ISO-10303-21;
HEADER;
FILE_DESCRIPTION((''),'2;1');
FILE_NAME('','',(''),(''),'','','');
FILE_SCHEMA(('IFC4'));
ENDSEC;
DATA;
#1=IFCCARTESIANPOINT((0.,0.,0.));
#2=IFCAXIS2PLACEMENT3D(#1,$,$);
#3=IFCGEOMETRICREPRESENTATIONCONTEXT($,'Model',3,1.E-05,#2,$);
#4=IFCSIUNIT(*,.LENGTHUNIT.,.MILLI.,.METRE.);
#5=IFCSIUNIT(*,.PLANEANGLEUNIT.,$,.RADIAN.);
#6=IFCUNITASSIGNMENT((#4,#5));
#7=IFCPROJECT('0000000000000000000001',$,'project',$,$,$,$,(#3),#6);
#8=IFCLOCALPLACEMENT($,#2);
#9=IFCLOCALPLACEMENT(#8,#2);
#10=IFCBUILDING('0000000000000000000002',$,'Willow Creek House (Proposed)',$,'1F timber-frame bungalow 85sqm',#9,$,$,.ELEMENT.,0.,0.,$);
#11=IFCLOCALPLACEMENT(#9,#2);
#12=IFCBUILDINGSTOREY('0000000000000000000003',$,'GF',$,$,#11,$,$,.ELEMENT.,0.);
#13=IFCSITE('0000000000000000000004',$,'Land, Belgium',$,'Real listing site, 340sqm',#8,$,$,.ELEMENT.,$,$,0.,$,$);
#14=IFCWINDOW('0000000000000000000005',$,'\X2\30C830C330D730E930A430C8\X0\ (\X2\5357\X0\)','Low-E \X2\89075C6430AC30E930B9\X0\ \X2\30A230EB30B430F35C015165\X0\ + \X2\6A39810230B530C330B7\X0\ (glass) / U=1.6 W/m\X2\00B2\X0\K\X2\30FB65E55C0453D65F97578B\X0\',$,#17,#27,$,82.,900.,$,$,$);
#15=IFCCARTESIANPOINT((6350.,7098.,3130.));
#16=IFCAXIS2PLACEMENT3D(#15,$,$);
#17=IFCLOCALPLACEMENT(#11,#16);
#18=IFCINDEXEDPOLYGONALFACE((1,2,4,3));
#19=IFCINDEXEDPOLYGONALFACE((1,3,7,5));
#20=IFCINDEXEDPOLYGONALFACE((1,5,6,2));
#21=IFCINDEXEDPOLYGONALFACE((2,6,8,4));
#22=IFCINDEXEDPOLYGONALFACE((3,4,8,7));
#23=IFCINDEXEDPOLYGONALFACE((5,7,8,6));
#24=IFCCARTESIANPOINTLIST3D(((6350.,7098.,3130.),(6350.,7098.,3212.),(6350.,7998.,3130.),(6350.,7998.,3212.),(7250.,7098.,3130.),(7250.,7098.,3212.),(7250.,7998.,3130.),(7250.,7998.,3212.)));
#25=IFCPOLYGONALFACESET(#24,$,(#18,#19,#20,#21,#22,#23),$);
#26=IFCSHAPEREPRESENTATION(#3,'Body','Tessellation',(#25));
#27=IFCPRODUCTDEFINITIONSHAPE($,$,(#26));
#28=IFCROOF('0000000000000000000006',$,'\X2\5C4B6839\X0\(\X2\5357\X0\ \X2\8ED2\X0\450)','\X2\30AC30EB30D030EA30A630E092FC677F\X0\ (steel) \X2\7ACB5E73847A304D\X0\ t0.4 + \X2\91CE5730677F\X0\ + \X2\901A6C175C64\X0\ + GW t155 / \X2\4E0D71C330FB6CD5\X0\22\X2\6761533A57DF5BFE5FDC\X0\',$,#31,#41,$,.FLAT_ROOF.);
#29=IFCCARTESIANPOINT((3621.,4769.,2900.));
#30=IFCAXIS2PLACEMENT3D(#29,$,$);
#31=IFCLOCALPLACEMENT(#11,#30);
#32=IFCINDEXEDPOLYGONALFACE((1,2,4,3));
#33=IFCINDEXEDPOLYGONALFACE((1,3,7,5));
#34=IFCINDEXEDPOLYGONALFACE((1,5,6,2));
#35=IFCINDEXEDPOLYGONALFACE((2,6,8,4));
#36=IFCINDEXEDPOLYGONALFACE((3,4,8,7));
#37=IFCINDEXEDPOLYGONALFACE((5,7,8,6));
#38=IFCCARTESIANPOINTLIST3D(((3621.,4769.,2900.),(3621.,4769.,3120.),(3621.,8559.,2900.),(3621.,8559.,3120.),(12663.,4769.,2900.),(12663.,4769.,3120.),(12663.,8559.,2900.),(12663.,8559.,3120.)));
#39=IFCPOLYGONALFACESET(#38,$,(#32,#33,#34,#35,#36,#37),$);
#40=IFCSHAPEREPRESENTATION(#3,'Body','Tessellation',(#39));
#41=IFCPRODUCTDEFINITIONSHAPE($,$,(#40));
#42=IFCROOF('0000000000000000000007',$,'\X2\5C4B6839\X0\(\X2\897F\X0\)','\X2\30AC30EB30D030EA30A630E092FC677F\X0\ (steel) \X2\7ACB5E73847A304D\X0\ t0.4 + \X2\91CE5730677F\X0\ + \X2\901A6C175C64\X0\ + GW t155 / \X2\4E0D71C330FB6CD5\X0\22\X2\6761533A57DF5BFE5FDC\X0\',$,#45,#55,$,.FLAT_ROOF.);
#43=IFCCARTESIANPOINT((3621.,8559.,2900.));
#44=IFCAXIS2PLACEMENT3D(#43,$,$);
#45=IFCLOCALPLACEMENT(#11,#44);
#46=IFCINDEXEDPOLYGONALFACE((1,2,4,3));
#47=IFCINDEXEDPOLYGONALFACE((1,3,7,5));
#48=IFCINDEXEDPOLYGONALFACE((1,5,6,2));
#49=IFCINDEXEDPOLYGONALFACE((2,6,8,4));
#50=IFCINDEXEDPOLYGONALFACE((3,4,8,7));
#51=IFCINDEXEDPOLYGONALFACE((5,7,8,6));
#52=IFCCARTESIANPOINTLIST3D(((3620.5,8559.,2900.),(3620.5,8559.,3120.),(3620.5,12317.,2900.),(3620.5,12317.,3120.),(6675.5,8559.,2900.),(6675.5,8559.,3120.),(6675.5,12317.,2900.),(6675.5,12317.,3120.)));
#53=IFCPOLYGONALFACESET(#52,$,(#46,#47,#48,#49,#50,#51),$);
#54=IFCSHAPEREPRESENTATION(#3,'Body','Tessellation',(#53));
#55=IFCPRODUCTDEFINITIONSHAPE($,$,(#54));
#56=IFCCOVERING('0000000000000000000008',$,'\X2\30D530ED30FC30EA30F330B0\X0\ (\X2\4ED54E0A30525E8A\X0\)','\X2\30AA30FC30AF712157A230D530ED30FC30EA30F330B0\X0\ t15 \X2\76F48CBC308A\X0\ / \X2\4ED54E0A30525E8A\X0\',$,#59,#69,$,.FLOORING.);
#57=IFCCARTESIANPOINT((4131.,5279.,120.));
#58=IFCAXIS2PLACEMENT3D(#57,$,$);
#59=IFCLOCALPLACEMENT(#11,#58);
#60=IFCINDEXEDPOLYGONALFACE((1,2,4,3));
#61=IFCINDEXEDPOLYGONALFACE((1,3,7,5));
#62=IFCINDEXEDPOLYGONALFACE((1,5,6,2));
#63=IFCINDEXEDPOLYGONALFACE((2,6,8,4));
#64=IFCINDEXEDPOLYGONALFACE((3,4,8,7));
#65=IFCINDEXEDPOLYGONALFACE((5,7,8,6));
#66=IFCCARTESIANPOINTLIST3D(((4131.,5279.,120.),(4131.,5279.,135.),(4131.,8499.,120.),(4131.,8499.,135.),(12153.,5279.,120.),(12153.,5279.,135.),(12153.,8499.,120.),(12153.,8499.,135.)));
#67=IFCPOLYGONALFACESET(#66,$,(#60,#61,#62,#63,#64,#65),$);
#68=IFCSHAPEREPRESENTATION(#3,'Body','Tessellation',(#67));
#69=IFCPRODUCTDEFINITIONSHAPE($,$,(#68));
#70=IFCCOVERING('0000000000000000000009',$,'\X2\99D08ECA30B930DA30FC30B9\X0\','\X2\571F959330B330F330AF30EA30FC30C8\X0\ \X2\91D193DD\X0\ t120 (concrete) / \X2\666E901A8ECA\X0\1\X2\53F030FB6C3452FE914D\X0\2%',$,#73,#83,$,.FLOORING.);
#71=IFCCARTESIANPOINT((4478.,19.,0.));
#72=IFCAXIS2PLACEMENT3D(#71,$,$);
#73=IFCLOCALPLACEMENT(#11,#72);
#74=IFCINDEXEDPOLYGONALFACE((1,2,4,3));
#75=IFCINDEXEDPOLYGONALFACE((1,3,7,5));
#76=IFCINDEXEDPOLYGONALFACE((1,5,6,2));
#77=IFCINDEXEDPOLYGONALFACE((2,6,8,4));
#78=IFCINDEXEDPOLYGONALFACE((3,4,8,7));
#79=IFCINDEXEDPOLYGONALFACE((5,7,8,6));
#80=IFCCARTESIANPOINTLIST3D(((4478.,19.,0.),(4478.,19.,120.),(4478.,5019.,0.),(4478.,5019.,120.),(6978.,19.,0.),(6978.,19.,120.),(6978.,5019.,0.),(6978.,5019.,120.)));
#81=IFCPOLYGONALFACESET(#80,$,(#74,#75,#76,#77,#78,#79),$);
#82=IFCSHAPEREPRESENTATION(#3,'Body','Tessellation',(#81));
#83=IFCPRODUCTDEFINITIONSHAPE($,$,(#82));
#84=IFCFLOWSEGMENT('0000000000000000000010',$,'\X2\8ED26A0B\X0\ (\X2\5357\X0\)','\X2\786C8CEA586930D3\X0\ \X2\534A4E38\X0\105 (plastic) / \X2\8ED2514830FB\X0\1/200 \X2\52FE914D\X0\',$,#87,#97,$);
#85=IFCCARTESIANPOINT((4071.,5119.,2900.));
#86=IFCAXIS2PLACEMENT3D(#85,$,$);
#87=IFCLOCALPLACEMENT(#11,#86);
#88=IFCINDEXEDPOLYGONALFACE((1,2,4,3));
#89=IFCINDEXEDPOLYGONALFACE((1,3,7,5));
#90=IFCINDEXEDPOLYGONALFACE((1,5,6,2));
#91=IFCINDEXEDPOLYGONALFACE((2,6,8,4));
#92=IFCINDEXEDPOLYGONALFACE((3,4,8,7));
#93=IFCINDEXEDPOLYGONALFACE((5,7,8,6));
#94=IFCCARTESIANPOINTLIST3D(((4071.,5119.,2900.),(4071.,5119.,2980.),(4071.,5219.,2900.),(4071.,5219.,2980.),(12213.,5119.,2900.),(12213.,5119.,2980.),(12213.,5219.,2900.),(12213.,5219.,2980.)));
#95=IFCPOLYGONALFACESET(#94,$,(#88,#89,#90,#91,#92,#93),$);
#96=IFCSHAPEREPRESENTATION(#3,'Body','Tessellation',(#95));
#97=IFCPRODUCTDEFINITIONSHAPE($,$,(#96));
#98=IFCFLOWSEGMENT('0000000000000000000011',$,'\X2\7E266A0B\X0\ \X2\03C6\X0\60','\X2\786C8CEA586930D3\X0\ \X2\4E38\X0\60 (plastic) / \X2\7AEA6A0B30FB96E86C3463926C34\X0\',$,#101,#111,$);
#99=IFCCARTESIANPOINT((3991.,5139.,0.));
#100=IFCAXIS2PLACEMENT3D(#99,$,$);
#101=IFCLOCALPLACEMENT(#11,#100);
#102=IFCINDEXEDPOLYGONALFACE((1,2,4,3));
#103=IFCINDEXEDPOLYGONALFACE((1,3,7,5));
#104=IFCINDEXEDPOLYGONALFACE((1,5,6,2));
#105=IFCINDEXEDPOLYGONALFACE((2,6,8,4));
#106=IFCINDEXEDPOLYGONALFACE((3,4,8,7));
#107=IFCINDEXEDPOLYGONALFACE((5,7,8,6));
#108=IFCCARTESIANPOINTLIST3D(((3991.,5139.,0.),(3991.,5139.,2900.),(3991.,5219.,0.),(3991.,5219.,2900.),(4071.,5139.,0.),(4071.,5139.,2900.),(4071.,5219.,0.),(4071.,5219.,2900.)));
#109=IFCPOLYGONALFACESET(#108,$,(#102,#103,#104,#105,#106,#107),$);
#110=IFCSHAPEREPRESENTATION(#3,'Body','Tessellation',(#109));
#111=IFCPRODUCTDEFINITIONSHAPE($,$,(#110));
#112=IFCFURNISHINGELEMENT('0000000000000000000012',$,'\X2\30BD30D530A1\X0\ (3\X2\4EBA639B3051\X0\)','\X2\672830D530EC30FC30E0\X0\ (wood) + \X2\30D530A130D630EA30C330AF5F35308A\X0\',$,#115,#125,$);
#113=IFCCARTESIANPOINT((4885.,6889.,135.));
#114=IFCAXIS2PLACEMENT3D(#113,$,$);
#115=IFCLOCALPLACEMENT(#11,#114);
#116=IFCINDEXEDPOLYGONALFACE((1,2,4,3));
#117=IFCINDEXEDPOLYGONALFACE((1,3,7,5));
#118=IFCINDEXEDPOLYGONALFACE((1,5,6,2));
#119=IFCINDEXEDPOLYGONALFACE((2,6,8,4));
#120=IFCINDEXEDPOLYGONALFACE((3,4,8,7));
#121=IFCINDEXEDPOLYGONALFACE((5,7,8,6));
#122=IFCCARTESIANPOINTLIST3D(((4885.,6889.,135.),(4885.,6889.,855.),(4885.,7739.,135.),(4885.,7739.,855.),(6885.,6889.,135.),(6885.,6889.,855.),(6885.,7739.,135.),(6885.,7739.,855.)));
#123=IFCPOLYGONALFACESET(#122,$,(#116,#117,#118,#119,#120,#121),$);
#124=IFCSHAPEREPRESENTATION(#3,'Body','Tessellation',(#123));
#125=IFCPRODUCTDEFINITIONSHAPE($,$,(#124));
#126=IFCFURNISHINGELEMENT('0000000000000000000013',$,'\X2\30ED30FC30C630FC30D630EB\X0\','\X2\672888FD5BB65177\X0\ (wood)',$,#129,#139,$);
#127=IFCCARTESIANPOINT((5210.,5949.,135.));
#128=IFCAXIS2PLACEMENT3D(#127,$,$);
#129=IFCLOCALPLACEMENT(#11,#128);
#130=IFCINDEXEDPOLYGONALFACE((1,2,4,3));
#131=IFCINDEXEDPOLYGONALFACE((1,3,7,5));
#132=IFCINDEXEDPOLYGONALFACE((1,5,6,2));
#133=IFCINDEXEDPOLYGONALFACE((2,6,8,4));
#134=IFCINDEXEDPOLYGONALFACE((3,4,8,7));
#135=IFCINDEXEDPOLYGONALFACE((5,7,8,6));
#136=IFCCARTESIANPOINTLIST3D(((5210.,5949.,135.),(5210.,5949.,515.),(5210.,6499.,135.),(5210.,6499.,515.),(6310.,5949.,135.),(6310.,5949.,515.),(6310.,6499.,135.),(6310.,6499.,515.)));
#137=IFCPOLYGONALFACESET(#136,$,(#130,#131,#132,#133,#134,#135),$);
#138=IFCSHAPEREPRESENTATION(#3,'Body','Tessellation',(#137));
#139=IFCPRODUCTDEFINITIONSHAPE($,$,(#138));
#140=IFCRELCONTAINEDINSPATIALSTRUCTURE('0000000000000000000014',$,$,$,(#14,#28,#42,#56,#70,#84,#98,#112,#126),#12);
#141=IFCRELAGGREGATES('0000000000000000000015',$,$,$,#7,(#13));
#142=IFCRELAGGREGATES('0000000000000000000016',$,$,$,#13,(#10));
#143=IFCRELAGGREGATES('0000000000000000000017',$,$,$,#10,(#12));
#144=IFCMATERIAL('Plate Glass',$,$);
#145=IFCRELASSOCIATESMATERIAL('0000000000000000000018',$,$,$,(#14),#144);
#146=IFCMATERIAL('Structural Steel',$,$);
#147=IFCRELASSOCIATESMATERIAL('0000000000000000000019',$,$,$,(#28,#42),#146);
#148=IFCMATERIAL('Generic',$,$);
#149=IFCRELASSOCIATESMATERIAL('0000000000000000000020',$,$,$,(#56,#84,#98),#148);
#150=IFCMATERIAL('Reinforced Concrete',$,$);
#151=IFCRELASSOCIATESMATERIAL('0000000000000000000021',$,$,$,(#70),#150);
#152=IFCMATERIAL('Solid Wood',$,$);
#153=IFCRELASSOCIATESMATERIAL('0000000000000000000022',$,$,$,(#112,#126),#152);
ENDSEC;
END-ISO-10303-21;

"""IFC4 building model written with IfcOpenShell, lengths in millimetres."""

from ifc_helpers import new_model, si_unit, frame, frame_2d, origin, place, context, project, spatial, rectangle, extrude, material, element, save


model = new_model("IFC4")

# Units and contexts
model_context = context("Model", 3, precision=1e-05, world=origin())
ifc_project = project(units=[si_unit("LENGTHUNIT", "METRE", prefix="MILLI"), si_unit("PLANEANGLEUNIT", "RADIAN")], contexts=[model_context])

# Site, building, storey
site_placement = place(None, origin())
site = spatial("IfcSite", under=ifc_project, at=site_placement, Name="Land, Belgium", ObjectType="Real listing site, 340sqm", CompositionType="ELEMENT", RefElevation=0.0)
building_placement = place(site_placement, origin())
building = spatial("IfcBuilding", under=site, at=building_placement, Name="Willow Creek House (Proposed)", ObjectType="1F timber-frame bungalow 85sqm", CompositionType="ELEMENT", ElevationOfRefHeight=0.0, ElevationOfTerrain=0.0)
storey_placement = place(building_placement, origin())
storey = spatial("IfcBuildingStorey", under=building, at=storey_placement, Name="GF", CompositionType="ELEMENT", Elevation=0.0)

# Shared definitions
ifc_material_1 = material(Name="Solid Wood")

# Shared definitions
ifc_material_2 = material(Name="Reinforced Concrete")

# Shared definitions
ifc_material_3 = material(Name="Plate Glass")

# Window
window_1_placement = place(storey_placement, frame((6350.0, 7098.0, 3130.0)))
element("IfcWindow", 1, at=window_1_placement, inside=storey, material=ifc_material_3, Name="トップライト (南)", Description="Low-E 複層ガラス アルゴン封入 + 樹脂サッシ (glass) / U=1.6 W/m²K・日射取得型", OverallHeight=82.0, OverallWidth=900.0, context=model_context, shape_type="SweptSolid", body=[
    extrude(rectangle(XDim=900.0, YDim=900.0, at=frame_2d((450.0, 450.0))), frame((6350.0, 7098.0, 3130.0)), (0.0, 0.0, 1.0), 82.0),
])

# Roofs
ifc_material_4 = material(Name="Structural Steel")
roof_1_placement = place(storey_placement, frame((3621.0, 4769.0, 2900.0)))
element("IfcRoof", 2, at=roof_1_placement, inside=storey, material=ifc_material_4, Name="屋根(南 軒450)", Description="ガルバリウム鋼板 (steel) 立平葺き t0.4 + 野地板 + 通気層 + GW t155 / 不燃・法22条区域対応", PredefinedType="FLAT_ROOF", context=model_context, shape_type="SweptSolid", body=[
    extrude(rectangle(XDim=9042.0, YDim=3790.0, at=frame_2d((4521.0, 1895.0))), frame((3621.0, 4769.0, 2900.0)), (0.0, 0.0, 1.0), 220.0),
])
roof_2_placement = place(storey_placement, frame((3621.0, 8559.0, 2900.0)))
element("IfcRoof", 3, at=roof_2_placement, inside=storey, material=ifc_material_4, Name="屋根(西)", Description="ガルバリウム鋼板 (steel) 立平葺き t0.4 + 野地板 + 通気層 + GW t155 / 不燃・法22条区域対応", PredefinedType="FLAT_ROOF", context=model_context, shape_type="SweptSolid", body=[
    extrude(rectangle(XDim=3055.0, YDim=3758.0, at=frame_2d((1527.0, 1879.0))), frame((3621.0, 8559.0, 2900.0)), (0.0, 0.0, 1.0), 220.0),
])

# Coverings
ifc_material_5 = material(Name="Generic")
covering_1_placement = place(storey_placement, frame((4131.0, 5279.0, 120.0)))
element("IfcCovering", 4, at=covering_1_placement, inside=storey, material=ifc_material_5, Name="フローリング (仕上げ床)", Description="オーク無垢フローリング t15 直貼り / 仕上げ床", PredefinedType="FLOORING", context=model_context, shape_type="SweptSolid", body=[
    extrude(rectangle(XDim=8022.0, YDim=3220.0, at=frame_2d((4011.0, 1610.0))), frame((4131.0, 5279.0, 120.0)), (0.0, 0.0, 1.0), 15.0),
])
covering_2_placement = place(storey_placement, frame((4478.0, 19.0, 0.0)))
element("IfcCovering", 5, at=covering_2_placement, inside=storey, material=ifc_material_2, Name="駐車スペース", Description="土間コンクリート 金鏝 t120 (concrete) / 普通車1台・水勾配2%", PredefinedType="FLOORING", context=model_context, shape_type="SweptSolid", body=[
    extrude(rectangle(XDim=2500.0, YDim=5000.0, at=frame_2d((1250.0, 2500.0))), frame((4478.0, 19.0, 0.0)), (0.0, 0.0, 1.0), 120.0),
])

# Flow segments
flow_segment_1_placement = place(storey_placement, frame((4071.0, 5119.0, 2900.0)))
element("IfcFlowSegment", 6, at=flow_segment_1_placement, inside=storey, material=ifc_material_5, Name="軒樋 (南)", Description="硬質塩ビ 半丸105 (plastic) / 軒先・1/200 勾配", context=model_context, shape_type="SweptSolid", body=[
    extrude(rectangle(XDim=8142.0, YDim=100.0, at=frame_2d((4071.0, 50.0))), frame((4071.0, 5119.0, 2900.0)), (0.0, 0.0, 1.0), 80.0),
])
flow_segment_2_placement = place(storey_placement, frame((3991.0, 5139.0, 0.0)))
element("IfcFlowSegment", 7, at=flow_segment_2_placement, inside=storey, material=ifc_material_5, Name="縦樋 φ60", Description="硬質塩ビ 丸60 (plastic) / 竪樋・雨水排水", context=model_context, shape_type="SweptSolid", body=[
    extrude(rectangle(XDim=80.0, YDim=80.0, at=frame_2d((40.0, 40.0))), frame((3991.0, 5139.0, 0.0)), (0.0, 0.0, 1.0), 2900.0),
])

# Furnishing elements
furnishing_1_placement = place(storey_placement, frame((4885.0, 6889.0, 135.0)))
element("IfcFurnishingElement", 8, at=furnishing_1_placement, inside=storey, material=ifc_material_1, Name="ソファ (3人掛け)", Description="木フレーム (wood) + ファブリック張り", context=model_context, shape_type="SweptSolid", body=[
    extrude(rectangle(XDim=2000.0, YDim=850.0, at=frame_2d((1000.0, 425.0))), frame((4885.0, 6889.0, 135.0)), (0.0, 0.0, 1.0), 720.0),
])
furnishing_2_placement = place(storey_placement, frame((5210.0, 5949.0, 135.0)))
element("IfcFurnishingElement", 9, at=furnishing_2_placement, inside=storey, material=ifc_material_1, Name="ローテーブル", Description="木製家具 (wood)", context=model_context, shape_type="SweptSolid", body=[
    extrude(rectangle(XDim=1100.0, YDim=550.0, at=frame_2d((550.0, 275.0))), frame((5210.0, 5949.0, 135.0)), (0.0, 0.0, 1.0), 380.0),
])

save(model, "model.ifc")
